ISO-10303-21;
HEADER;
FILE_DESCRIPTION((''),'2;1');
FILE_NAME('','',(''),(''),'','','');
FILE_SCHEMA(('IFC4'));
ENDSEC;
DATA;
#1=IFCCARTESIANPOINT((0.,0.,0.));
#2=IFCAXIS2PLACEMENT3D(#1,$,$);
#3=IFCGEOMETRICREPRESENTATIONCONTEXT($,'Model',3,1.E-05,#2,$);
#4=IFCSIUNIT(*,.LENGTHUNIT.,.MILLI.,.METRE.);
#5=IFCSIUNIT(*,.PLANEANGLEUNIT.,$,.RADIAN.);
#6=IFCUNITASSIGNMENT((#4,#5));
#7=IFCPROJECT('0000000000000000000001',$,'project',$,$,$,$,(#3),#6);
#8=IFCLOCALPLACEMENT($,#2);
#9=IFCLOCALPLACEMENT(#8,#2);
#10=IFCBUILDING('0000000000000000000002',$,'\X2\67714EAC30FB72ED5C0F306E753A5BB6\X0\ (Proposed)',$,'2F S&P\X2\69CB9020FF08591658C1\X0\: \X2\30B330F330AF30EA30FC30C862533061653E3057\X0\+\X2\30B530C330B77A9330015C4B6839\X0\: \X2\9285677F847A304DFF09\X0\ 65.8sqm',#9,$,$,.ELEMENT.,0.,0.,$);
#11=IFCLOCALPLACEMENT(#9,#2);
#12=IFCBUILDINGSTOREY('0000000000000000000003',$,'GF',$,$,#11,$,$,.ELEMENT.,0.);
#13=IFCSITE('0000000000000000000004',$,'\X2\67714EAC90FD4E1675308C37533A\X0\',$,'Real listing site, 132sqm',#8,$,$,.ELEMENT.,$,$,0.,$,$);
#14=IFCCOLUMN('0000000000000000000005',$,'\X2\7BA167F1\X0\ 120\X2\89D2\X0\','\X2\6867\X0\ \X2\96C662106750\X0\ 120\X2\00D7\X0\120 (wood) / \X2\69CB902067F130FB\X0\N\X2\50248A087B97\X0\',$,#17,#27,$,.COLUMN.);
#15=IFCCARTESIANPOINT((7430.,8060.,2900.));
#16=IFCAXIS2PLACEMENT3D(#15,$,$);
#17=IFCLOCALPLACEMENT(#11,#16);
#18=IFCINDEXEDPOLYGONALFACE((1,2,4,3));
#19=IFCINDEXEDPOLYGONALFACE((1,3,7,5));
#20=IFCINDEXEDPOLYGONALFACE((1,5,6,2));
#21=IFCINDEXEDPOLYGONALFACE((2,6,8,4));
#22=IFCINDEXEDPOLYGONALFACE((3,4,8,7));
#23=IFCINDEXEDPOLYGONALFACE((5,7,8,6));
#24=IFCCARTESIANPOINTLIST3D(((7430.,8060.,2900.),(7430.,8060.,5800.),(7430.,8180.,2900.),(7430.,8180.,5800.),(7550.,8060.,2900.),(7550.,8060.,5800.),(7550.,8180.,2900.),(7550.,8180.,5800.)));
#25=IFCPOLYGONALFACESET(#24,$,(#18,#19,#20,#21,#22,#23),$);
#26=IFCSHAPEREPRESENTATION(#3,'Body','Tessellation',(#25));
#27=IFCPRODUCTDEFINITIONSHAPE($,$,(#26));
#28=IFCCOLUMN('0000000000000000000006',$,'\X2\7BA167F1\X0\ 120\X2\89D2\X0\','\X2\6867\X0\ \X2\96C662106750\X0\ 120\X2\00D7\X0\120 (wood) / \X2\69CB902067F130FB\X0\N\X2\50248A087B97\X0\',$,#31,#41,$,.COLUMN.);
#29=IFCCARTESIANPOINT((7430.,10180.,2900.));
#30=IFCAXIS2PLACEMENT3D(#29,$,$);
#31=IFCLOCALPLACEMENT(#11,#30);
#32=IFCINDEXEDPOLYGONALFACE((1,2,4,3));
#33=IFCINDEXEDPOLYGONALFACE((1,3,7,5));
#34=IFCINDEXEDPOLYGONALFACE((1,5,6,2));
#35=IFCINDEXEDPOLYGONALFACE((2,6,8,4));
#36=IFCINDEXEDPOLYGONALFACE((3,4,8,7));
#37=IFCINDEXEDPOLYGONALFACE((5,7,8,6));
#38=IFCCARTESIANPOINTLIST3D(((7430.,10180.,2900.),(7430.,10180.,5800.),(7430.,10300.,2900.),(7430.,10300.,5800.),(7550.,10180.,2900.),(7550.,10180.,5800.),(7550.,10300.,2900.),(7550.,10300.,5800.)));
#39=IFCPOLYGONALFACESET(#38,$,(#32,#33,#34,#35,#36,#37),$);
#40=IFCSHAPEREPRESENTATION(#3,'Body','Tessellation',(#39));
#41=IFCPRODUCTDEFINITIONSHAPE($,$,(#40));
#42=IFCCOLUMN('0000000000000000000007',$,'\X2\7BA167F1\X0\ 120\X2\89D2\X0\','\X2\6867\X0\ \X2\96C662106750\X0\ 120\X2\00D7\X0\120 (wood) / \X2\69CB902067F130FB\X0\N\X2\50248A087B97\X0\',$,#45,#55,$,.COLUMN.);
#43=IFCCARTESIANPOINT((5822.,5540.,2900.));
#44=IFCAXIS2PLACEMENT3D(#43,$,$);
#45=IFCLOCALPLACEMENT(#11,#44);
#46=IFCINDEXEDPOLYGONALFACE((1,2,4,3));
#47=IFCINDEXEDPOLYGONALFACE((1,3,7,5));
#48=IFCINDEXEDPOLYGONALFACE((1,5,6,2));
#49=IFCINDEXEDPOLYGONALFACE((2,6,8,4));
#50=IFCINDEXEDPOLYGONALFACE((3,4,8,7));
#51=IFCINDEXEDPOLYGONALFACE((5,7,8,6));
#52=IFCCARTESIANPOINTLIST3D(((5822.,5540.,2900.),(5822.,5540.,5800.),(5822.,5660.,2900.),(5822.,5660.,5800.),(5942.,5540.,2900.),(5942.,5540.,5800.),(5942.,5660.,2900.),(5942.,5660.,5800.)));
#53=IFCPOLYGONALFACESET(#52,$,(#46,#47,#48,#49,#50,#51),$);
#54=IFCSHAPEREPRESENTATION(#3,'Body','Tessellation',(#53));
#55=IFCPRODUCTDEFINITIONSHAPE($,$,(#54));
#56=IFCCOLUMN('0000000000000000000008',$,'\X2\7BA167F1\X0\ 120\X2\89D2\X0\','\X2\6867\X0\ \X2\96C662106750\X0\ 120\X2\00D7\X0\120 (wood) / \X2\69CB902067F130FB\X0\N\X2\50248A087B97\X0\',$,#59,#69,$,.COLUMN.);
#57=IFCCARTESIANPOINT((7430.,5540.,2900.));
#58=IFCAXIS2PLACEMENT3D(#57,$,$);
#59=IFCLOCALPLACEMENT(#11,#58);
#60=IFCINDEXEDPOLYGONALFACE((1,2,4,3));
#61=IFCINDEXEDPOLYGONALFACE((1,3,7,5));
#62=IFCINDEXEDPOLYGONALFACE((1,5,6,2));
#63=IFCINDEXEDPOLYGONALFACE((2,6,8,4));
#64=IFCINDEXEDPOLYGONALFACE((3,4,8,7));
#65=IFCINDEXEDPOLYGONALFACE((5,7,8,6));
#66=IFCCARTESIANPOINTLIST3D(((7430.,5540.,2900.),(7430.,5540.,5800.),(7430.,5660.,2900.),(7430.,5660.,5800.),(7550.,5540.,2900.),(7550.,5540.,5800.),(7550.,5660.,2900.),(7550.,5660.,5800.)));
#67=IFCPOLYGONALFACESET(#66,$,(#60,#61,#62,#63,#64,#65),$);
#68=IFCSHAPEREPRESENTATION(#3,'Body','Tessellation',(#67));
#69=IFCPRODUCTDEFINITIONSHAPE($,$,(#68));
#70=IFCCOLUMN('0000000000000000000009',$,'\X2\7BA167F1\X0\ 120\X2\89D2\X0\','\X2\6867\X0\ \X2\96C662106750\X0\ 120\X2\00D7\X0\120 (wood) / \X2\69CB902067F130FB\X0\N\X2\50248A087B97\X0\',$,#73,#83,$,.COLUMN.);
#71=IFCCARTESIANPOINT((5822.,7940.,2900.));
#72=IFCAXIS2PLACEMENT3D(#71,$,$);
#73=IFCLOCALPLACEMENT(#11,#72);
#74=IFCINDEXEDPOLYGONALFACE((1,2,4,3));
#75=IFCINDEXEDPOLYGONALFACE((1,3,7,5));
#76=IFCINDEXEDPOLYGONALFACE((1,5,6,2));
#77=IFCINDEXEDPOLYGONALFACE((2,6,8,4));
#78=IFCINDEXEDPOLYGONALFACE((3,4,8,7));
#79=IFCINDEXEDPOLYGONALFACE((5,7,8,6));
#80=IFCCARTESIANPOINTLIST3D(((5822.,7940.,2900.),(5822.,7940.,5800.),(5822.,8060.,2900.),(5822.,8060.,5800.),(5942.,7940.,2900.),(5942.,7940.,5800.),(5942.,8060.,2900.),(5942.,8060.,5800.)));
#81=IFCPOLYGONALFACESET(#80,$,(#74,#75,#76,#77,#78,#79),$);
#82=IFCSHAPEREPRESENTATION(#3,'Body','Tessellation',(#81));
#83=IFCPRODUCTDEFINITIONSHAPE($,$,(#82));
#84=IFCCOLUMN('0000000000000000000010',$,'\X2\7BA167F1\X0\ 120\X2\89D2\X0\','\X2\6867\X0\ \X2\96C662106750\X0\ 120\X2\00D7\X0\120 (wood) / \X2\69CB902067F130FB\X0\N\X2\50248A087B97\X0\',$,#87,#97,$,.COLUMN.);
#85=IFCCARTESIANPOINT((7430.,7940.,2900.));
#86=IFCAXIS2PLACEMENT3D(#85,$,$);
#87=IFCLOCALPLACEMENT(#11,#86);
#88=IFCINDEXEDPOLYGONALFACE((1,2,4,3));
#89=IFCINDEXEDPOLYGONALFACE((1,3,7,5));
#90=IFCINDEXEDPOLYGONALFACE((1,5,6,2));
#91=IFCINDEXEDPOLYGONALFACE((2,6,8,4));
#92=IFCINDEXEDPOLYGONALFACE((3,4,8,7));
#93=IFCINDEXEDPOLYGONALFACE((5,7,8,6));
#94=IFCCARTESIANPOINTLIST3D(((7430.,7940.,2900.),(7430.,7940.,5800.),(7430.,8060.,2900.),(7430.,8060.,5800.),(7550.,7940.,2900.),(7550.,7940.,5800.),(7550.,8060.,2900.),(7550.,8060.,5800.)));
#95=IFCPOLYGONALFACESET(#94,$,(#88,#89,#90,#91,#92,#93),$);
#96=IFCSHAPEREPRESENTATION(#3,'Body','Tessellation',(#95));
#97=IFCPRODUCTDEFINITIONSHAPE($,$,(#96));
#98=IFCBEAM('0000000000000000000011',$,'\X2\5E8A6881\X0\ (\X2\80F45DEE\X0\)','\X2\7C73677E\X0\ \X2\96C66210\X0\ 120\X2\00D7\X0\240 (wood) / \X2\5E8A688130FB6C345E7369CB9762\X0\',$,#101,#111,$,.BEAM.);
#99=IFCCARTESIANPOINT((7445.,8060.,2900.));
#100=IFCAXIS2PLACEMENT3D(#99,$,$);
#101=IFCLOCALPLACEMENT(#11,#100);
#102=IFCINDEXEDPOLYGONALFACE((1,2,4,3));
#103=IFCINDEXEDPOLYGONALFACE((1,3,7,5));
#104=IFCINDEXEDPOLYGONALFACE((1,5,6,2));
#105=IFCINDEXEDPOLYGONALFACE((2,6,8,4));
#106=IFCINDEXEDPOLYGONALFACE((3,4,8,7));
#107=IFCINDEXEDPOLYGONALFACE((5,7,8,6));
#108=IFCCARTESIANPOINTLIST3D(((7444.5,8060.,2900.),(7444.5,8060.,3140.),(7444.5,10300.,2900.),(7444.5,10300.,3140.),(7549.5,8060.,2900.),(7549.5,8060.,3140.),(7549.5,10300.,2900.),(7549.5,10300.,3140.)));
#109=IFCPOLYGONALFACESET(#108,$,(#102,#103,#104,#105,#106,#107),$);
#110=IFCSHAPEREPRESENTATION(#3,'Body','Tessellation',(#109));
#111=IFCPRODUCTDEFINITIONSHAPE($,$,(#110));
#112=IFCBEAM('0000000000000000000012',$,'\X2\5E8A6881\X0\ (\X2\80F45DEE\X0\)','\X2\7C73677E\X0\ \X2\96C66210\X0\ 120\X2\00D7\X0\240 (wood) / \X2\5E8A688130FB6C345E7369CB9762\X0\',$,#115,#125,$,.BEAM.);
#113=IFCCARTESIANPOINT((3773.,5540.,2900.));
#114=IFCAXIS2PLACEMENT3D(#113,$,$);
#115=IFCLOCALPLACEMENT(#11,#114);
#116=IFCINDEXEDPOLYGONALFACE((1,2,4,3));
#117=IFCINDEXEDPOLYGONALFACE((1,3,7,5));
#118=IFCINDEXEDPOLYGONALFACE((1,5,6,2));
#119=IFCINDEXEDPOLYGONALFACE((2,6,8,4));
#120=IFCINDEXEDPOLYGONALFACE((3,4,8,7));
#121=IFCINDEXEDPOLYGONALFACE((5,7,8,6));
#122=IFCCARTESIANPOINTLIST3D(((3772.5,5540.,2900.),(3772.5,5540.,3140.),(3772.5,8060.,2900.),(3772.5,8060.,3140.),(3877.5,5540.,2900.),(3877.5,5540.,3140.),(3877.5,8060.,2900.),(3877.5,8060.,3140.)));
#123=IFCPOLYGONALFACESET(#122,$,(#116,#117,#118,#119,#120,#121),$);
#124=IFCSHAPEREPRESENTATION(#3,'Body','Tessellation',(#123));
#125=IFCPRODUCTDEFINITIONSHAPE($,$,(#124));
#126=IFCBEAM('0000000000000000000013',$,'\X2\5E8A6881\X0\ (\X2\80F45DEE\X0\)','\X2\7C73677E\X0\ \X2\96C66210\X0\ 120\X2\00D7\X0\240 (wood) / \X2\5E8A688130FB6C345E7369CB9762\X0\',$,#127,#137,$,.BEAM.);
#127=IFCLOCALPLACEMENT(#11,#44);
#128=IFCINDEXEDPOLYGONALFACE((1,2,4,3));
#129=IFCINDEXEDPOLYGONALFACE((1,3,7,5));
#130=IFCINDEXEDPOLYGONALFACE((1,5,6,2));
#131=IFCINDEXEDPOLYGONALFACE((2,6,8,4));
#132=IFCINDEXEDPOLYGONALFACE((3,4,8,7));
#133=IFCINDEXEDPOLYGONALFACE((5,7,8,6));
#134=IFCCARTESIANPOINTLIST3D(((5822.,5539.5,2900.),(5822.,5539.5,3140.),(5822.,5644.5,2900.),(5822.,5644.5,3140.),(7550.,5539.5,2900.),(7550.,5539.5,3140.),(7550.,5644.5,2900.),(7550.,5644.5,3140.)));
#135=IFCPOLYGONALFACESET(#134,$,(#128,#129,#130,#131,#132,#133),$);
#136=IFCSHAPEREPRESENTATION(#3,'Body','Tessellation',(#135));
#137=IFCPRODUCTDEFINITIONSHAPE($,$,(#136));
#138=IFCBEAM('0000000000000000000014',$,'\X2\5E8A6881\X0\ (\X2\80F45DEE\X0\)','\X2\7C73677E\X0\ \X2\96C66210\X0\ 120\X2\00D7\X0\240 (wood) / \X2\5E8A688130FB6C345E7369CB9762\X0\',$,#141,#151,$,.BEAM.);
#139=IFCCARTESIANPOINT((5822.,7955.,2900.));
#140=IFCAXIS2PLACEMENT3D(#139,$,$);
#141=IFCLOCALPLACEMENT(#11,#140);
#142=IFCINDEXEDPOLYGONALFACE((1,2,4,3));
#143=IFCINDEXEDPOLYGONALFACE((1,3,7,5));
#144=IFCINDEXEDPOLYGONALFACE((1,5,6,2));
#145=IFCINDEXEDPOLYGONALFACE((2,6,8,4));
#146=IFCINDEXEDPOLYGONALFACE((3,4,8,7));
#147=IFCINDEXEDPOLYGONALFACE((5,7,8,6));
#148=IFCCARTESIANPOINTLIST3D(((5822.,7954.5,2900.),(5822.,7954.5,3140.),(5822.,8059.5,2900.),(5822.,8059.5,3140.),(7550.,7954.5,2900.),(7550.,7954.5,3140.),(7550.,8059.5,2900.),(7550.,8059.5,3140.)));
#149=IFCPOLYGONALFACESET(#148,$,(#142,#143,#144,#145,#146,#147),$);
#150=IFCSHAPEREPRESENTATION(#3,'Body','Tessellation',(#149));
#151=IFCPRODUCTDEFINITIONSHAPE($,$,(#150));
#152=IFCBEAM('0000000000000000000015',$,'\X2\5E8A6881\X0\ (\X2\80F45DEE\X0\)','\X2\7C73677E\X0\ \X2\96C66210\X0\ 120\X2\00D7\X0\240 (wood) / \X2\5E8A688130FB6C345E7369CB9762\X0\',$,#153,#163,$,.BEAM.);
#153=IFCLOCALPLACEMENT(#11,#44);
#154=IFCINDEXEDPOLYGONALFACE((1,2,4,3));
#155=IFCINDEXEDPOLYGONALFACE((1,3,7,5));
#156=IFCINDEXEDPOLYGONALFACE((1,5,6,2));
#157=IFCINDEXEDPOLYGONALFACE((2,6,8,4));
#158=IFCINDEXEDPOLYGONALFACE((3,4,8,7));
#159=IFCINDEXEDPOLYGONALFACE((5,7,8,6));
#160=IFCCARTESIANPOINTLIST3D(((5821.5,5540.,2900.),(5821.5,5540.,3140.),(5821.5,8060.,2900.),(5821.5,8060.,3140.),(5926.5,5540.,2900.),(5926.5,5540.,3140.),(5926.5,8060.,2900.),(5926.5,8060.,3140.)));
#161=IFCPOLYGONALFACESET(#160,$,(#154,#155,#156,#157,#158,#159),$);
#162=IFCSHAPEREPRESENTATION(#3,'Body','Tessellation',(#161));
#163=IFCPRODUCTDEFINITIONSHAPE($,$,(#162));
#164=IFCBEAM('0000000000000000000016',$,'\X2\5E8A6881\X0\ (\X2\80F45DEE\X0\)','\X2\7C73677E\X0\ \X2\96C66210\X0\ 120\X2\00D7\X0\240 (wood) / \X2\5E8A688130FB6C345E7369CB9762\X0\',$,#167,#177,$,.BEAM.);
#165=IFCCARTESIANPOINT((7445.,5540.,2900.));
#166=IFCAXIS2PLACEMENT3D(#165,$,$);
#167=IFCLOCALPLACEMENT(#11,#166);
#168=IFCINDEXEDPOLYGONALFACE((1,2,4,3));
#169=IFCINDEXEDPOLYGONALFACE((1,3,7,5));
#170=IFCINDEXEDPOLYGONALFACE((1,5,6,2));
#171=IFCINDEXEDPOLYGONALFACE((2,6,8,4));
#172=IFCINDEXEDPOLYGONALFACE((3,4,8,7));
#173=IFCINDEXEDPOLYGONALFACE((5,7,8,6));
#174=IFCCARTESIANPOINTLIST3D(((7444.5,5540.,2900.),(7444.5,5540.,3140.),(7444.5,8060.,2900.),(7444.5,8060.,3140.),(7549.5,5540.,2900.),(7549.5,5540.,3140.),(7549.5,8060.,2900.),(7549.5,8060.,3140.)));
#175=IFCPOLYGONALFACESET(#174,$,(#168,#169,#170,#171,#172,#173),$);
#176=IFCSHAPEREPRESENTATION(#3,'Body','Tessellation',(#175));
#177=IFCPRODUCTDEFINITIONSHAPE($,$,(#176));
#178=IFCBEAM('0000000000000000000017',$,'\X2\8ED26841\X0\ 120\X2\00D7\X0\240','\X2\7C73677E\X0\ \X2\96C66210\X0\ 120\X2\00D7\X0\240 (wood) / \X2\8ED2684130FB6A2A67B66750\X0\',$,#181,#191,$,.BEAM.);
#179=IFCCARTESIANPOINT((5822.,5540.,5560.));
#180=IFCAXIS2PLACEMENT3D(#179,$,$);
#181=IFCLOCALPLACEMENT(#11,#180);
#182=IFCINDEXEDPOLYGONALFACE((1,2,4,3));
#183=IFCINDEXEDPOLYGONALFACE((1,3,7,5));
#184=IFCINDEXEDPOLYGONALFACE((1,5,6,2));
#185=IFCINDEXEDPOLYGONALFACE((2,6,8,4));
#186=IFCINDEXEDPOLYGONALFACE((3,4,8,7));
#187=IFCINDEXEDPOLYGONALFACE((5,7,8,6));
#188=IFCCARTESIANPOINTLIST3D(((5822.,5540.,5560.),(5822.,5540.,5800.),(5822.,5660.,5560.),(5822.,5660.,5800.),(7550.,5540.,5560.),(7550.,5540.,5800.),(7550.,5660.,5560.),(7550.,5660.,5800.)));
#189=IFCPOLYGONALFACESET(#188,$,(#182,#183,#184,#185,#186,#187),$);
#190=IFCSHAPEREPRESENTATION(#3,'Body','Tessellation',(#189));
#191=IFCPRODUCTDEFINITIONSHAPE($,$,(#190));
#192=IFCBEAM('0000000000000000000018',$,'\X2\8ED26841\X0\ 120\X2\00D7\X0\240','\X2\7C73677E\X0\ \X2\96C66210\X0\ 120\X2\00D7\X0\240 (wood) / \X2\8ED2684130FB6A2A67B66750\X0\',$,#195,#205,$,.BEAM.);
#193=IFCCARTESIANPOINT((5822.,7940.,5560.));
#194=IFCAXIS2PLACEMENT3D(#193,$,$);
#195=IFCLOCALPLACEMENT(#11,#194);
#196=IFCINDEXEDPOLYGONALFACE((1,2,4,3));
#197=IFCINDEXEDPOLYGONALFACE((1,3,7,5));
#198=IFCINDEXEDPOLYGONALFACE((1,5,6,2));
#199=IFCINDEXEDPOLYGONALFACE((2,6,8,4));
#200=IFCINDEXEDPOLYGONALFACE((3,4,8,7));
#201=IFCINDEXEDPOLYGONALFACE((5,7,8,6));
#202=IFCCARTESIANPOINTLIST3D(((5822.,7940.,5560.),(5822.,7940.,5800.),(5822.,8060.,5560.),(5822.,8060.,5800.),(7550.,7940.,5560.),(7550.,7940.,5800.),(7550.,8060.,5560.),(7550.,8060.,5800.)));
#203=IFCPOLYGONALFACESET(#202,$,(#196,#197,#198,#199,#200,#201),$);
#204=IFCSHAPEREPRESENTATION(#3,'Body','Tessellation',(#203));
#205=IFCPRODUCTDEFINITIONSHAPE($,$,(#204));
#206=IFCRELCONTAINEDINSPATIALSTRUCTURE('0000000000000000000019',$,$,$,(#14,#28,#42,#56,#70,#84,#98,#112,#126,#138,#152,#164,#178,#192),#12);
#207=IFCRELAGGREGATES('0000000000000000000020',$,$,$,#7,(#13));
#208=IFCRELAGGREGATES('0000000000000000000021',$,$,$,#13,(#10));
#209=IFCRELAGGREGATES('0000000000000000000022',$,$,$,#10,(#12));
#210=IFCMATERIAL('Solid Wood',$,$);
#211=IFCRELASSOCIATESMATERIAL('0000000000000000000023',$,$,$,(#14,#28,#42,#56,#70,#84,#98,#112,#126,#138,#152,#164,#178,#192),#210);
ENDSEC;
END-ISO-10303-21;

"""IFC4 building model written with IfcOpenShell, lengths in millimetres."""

from ifc_helpers import new_model, si_unit, frame, frame_2d, origin, place, context, project, spatial, rectangle, extrude, material, element, save


model = new_model("IFC4")

# Units and contexts
model_context = context("Model", 3, precision=1e-05, world=origin())
ifc_project = project(units=[si_unit("LENGTHUNIT", "METRE", prefix="MILLI"), si_unit("PLANEANGLEUNIT", "RADIAN")], contexts=[model_context])

# Site, building, storey
site_placement = place(None, origin())
site = spatial("IfcSite", under=ifc_project, at=site_placement, Name="東京都世田谷区", ObjectType="Real listing site, 132sqm", CompositionType="ELEMENT", RefElevation=0.0)
building_placement = place(site_placement, origin())
building = spatial("IfcBuilding", under=site, at=building_placement, Name="東京・狭小の町家 (Proposed)", ObjectType="2F S&P構造（外壁: コンクリート打ち放し+サッシ窓、屋根: 銅板葺き） 65.8sqm", CompositionType="ELEMENT", ElevationOfRefHeight=0.0, ElevationOfTerrain=0.0)
storey_placement = place(building_placement, origin())
storey = spatial("IfcBuildingStorey", under=building, at=storey_placement, Name="GF", CompositionType="ELEMENT", Elevation=0.0)

# Columns
ifc_material_1 = material(Name="Solid Wood")
column_1_placement = place(storey_placement, frame((7430.0, 8060.0, 2900.0)))
element("IfcColumn", 1, at=column_1_placement, inside=storey, material=ifc_material_1, Name="管柱 120角", Description="桧 集成材 120×120 (wood) / 構造柱・N値計算", PredefinedType="COLUMN", context=model_context, shape_type="SweptSolid", body=[
    extrude(rectangle(XDim=120.0, YDim=120.0, at=frame_2d((60.0, 60.0))), frame((7430.0, 8060.0, 2900.0)), (0.0, 0.0, 1.0), 2900.0),
])
column_2_placement = place(storey_placement, frame((7430.0, 10180.0, 2900.0)))
element("IfcColumn", 2, at=column_2_placement, inside=storey, material=ifc_material_1, Name="管柱 120角", Description="桧 集成材 120×120 (wood) / 構造柱・N値計算", PredefinedType="COLUMN", context=model_context, shape_type="SweptSolid", body=[
    extrude(rectangle(XDim=120.0, YDim=120.0, at=frame_2d((60.0, 60.0))), frame((7430.0, 10180.0, 2900.0)), (0.0, 0.0, 1.0), 2900.0),
])
column_3_placement = place(storey_placement, frame((5822.0, 5540.0, 2900.0)))
element("IfcColumn", 3, at=column_3_placement, inside=storey, material=ifc_material_1, Name="管柱 120角", Description="桧 集成材 120×120 (wood) / 構造柱・N値計算", PredefinedType="COLUMN", context=model_context, shape_type="SweptSolid", body=[
    extrude(rectangle(XDim=120.0, YDim=120.0, at=frame_2d((60.0, 60.0))), frame((5822.0, 5540.0, 2900.0)), (0.0, 0.0, 1.0), 2900.0),
])
column_4_placement = place(storey_placement, frame((7430.0, 5540.0, 2900.0)))
element("IfcColumn", 4, at=column_4_placement, inside=storey, material=ifc_material_1, Name="管柱 120角", Description="桧 集成材 120×120 (wood) / 構造柱・N値計算", PredefinedType="COLUMN", context=model_context, shape_type="SweptSolid", body=[
    extrude(rectangle(XDim=120.0, YDim=120.0, at=frame_2d((60.0, 60.0))), frame((7430.0, 5540.0, 2900.0)), (0.0, 0.0, 1.0), 2900.0),
])
column_5_placement = place(storey_placement, frame((5822.0, 7940.0, 2900.0)))
element("IfcColumn", 5, at=column_5_placement, inside=storey, material=ifc_material_1, Name="管柱 120角", Description="桧 集成材 120×120 (wood) / 構造柱・N値計算", PredefinedType="COLUMN", context=model_context, shape_type="SweptSolid", body=[
    extrude(rectangle(XDim=120.0, YDim=120.0, at=frame_2d((60.0, 60.0))), frame((5822.0, 7940.0, 2900.0)), (0.0, 0.0, 1.0), 2900.0),
])
column_6_placement = place(storey_placement, frame((7430.0, 7940.0, 2900.0)))
element("IfcColumn", 6, at=column_6_placement, inside=storey, material=ifc_material_1, Name="管柱 120角", Description="桧 集成材 120×120 (wood) / 構造柱・N値計算", PredefinedType="COLUMN", context=model_context, shape_type="SweptSolid", body=[
    extrude(rectangle(XDim=120.0, YDim=120.0, at=frame_2d((60.0, 60.0))), frame((7430.0, 7940.0, 2900.0)), (0.0, 0.0, 1.0), 2900.0),
])

# Beams
beam_1_placement = place(storey_placement, frame((7445.0, 8060.0, 2900.0)))
element("IfcBeam", 7, at=beam_1_placement, inside=storey, material=ifc_material_1, Name="床梁 (胴差)", Description="米松 集成 120×240 (wood) / 床梁・水平構面", PredefinedType="BEAM", context=model_context, shape_type="SweptSolid", body=[
    extrude(rectangle(XDim=105.0, YDim=2240.0, at=frame_2d((52.0, 1120.0))), frame((7445.0, 8060.0, 2900.0)), (0.0, 0.0, 1.0), 240.0),
])
beam_2_placement = place(storey_placement, frame((3773.0, 5540.0, 2900.0)))
element("IfcBeam", 8, at=beam_2_placement, inside=storey, material=ifc_material_1, Name="床梁 (胴差)", Description="米松 集成 120×240 (wood) / 床梁・水平構面", PredefinedType="BEAM", context=model_context, shape_type="SweptSolid", body=[
    extrude(rectangle(XDim=105.0, YDim=2520.0, at=frame_2d((52.0, 1260.0))), frame((3773.0, 5540.0, 2900.0)), (0.0, 0.0, 1.0), 240.0),
])
beam_3_placement = place(storey_placement, frame((5822.0, 5540.0, 2900.0)))
element("IfcBeam", 9, at=beam_3_placement, inside=storey, material=ifc_material_1, Name="床梁 (胴差)", Description="米松 集成 120×240 (wood) / 床梁・水平構面", PredefinedType="BEAM", context=model_context, shape_type="SweptSolid", body=[
    extrude(rectangle(XDim=1728.0, YDim=105.0, at=frame_2d((864.0, 52.0))), frame((5822.0, 5540.0, 2900.0)), (0.0, 0.0, 1.0), 240.0),
])
beam_4_placement = place(storey_placement, frame((5822.0, 7955.0, 2900.0)))
element("IfcBeam", 10, at=beam_4_placement, inside=storey, material=ifc_material_1, Name="床梁 (胴差)", Description="米松 集成 120×240 (wood) / 床梁・水平構面", PredefinedType="BEAM", context=model_context, shape_type="SweptSolid", body=[
    extrude(rectangle(XDim=1728.0, YDim=105.0, at=frame_2d((864.0, 52.0))), frame((5822.0, 7955.0, 2900.0)), (0.0, 0.0, 1.0), 240.0),
])
beam_5_placement = place(storey_placement, frame((5822.0, 5540.0, 2900.0)))
element("IfcBeam", 11, at=beam_5_placement, inside=storey, material=ifc_material_1, Name="床梁 (胴差)", Description="米松 集成 120×240 (wood) / 床梁・水平構面", PredefinedType="BEAM", context=model_context, shape_type="SweptSolid", body=[
    extrude(rectangle(XDim=105.0, YDim=2520.0, at=frame_2d((52.0, 1260.0))), frame((5822.0, 5540.0, 2900.0)), (0.0, 0.0, 1.0), 240.0),
])
beam_6_placement = place(storey_placement, frame((7445.0, 5540.0, 2900.0)))
element("IfcBeam", 12, at=beam_6_placement, inside=storey, material=ifc_material_1, Name="床梁 (胴差)", Description="米松 集成 120×240 (wood) / 床梁・水平構面", PredefinedType="BEAM", context=model_context, shape_type="SweptSolid", body=[
    extrude(rectangle(XDim=105.0, YDim=2520.0, at=frame_2d((52.0, 1260.0))), frame((7445.0, 5540.0, 2900.0)), (0.0, 0.0, 1.0), 240.0),
])
beam_7_placement = place(storey_placement, frame((5822.0, 5540.0, 5560.0)))
element("IfcBeam", 13, at=beam_7_placement, inside=storey, material=ifc_material_1, Name="軒桁 120×240", Description="米松 集成 120×240 (wood) / 軒桁・横架材", PredefinedType="BEAM", context=model_context, shape_type="SweptSolid", body=[
    extrude(rectangle(XDim=1728.0, YDim=120.0, at=frame_2d((864.0, 60.0))), frame((5822.0, 5540.0, 5560.0)), (0.0, 0.0, 1.0), 240.0),
])
beam_8_placement = place(storey_placement, frame((5822.0, 7940.0, 5560.0)))
element("IfcBeam", 14, at=beam_8_placement, inside=storey, material=ifc_material_1, Name="軒桁 120×240", Description="米松 集成 120×240 (wood) / 軒桁・横架材", PredefinedType="BEAM", context=model_context, shape_type="SweptSolid", body=[
    extrude(rectangle(XDim=1728.0, YDim=120.0, at=frame_2d((864.0, 60.0))), frame((5822.0, 7940.0, 5560.0)), (0.0, 0.0, 1.0), 240.0),
])

save(model, "model.ifc")
